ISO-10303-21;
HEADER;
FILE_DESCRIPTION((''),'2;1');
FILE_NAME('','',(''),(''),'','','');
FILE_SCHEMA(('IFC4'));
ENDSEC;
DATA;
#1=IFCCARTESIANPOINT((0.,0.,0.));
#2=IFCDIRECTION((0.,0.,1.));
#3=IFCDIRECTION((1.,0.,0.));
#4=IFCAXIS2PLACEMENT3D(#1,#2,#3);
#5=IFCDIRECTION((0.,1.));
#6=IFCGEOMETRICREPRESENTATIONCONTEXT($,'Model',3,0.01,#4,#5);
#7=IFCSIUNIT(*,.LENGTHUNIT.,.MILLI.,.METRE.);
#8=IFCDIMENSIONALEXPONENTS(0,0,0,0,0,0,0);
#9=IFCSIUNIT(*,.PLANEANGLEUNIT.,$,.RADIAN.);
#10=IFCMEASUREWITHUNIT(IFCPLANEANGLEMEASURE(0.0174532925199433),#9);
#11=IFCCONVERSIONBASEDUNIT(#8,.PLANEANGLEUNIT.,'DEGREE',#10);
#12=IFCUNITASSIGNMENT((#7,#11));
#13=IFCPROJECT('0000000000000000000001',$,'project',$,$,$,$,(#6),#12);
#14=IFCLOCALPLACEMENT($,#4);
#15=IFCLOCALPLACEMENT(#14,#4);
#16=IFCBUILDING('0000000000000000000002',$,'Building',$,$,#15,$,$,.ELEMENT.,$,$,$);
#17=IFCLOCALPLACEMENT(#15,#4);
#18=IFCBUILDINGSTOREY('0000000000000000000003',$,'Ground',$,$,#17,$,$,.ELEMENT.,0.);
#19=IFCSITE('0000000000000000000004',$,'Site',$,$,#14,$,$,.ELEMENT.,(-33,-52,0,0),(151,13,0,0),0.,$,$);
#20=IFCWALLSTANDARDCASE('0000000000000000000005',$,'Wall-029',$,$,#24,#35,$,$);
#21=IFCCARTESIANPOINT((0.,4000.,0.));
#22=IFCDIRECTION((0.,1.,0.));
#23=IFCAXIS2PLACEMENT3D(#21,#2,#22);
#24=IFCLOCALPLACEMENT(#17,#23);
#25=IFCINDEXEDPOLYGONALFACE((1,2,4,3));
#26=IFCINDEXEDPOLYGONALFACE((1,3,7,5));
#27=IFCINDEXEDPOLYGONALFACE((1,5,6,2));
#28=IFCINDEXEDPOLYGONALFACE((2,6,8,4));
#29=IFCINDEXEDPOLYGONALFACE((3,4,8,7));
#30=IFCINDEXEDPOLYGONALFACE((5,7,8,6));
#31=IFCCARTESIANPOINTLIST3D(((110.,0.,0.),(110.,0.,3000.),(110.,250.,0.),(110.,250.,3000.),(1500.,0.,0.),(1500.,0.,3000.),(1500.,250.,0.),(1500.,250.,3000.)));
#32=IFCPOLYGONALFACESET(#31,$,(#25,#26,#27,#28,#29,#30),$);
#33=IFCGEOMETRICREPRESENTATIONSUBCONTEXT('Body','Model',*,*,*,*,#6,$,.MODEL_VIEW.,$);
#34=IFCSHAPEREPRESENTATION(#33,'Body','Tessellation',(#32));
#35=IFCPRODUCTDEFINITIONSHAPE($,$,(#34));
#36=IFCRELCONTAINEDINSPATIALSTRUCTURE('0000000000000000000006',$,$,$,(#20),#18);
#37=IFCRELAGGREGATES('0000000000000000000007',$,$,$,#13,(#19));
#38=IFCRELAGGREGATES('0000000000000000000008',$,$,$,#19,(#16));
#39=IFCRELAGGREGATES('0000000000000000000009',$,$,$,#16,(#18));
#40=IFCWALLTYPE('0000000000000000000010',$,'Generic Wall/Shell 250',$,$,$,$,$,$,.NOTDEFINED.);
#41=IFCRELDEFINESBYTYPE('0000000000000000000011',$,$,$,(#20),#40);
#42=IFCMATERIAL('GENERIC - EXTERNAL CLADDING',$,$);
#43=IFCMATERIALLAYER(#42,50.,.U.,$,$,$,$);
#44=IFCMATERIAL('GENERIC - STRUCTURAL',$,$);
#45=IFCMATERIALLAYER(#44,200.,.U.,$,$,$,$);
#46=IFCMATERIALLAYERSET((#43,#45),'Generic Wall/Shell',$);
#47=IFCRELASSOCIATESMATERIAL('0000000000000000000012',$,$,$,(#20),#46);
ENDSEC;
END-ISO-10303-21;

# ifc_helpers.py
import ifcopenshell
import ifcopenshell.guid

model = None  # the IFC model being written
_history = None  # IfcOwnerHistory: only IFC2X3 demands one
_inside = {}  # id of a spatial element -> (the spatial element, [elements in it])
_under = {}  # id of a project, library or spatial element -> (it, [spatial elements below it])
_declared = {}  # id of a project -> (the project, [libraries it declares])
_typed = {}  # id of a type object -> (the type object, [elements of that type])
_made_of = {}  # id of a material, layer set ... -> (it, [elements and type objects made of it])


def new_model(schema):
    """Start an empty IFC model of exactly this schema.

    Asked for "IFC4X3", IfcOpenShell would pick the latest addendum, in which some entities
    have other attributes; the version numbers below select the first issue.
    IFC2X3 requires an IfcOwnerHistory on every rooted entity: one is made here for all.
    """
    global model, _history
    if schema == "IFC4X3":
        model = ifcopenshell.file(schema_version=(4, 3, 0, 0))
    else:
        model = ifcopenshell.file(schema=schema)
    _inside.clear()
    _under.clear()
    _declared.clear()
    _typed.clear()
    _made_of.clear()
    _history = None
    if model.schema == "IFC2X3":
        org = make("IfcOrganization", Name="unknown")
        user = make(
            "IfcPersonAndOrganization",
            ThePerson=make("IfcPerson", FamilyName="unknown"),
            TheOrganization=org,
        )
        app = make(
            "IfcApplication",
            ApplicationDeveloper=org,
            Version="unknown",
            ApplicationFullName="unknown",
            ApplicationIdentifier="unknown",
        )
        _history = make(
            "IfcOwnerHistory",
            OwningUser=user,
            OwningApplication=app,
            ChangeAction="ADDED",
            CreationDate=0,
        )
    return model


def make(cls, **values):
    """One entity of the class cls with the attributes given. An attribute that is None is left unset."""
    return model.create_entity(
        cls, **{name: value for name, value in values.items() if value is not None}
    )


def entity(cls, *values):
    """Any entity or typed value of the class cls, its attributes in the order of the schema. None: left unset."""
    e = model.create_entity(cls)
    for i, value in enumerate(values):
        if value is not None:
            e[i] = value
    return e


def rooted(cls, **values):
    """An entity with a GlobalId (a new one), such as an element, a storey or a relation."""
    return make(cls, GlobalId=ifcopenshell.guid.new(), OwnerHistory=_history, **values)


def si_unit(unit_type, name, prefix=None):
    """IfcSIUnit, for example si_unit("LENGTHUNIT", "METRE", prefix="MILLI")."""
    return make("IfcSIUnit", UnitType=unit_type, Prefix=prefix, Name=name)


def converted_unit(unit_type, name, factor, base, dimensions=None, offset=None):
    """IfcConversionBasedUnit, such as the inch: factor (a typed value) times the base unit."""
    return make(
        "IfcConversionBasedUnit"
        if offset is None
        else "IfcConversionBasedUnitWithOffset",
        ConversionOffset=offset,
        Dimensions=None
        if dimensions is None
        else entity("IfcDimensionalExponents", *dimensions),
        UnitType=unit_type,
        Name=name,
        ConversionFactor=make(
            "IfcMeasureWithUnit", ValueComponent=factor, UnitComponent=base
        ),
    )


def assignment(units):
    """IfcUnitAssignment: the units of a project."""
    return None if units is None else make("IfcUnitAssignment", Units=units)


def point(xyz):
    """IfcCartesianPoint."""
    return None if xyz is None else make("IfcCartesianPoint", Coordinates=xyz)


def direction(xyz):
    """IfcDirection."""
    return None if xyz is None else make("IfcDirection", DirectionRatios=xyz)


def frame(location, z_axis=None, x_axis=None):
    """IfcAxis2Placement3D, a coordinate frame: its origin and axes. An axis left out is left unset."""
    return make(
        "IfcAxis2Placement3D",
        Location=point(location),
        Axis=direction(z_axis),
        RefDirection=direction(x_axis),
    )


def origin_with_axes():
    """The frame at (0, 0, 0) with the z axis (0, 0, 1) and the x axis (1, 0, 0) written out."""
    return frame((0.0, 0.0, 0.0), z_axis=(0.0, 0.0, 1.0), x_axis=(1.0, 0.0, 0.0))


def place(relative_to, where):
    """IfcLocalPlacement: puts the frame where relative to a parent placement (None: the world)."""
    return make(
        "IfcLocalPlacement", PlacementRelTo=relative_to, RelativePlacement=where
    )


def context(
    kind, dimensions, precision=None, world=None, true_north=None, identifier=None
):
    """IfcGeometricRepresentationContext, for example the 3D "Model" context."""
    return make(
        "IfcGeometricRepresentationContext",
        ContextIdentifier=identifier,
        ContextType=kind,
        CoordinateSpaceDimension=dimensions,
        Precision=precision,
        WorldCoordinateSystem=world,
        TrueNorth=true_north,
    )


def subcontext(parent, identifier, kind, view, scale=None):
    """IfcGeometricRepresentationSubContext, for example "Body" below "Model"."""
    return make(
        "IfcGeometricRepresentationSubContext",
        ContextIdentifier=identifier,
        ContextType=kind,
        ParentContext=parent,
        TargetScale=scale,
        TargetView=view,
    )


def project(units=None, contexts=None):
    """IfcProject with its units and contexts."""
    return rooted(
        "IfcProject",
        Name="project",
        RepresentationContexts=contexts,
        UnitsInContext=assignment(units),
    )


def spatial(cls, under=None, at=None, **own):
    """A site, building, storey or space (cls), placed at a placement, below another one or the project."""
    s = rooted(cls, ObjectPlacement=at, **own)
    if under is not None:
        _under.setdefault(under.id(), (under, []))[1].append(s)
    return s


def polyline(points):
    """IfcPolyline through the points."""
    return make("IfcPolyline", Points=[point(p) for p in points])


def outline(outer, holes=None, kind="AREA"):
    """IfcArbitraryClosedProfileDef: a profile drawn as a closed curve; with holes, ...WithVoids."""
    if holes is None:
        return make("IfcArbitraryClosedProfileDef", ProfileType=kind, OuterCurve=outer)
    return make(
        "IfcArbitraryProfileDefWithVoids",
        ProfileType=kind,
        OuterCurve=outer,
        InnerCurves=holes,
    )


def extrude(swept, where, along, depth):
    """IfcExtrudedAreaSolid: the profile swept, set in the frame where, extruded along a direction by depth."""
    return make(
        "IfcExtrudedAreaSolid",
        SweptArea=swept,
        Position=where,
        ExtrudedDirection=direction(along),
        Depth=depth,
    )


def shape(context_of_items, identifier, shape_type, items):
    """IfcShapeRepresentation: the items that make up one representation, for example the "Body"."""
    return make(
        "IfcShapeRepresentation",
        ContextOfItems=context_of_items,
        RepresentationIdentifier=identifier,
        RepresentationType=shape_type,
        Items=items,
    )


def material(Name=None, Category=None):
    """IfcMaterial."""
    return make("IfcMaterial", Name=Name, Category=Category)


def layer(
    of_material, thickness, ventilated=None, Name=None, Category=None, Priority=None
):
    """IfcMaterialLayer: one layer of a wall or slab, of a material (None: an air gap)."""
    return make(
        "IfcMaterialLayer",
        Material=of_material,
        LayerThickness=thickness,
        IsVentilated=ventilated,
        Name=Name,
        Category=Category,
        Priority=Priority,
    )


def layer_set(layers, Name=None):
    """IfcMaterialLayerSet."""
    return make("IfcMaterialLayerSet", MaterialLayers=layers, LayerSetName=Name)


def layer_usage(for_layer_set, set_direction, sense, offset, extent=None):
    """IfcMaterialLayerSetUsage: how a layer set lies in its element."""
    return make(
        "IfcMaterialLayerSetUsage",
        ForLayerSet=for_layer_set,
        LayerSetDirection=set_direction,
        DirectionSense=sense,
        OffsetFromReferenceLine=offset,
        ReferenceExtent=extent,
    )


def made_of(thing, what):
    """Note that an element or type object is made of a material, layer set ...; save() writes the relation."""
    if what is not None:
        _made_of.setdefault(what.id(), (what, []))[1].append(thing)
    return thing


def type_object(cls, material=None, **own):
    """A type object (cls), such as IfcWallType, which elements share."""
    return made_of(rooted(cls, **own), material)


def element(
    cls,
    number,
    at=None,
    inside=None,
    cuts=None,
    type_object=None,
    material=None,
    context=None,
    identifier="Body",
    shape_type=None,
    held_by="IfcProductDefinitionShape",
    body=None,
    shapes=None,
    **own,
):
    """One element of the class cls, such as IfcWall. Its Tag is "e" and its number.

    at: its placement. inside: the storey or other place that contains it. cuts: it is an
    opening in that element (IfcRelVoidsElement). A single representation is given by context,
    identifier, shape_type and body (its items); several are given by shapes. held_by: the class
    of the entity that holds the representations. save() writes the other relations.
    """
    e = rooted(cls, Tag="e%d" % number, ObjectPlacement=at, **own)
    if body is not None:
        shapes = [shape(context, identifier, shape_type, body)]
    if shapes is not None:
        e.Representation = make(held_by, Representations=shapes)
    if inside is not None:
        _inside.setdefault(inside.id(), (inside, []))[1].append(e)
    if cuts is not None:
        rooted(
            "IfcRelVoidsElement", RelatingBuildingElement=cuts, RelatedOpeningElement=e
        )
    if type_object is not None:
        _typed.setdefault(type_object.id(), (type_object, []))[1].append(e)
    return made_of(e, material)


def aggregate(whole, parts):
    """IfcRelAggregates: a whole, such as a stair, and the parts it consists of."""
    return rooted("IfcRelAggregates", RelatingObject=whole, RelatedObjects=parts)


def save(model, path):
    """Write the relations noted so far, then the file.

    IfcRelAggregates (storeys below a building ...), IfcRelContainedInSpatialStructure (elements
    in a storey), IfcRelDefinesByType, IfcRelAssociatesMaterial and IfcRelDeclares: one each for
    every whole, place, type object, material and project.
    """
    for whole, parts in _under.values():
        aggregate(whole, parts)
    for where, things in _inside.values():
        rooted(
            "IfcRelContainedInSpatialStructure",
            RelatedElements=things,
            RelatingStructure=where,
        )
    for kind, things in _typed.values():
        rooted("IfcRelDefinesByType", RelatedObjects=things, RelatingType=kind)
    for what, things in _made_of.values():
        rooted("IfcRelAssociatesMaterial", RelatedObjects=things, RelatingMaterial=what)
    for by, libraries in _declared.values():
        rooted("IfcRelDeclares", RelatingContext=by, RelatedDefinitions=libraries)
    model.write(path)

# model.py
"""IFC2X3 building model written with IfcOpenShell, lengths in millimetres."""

from ifc_helpers import new_model, entity, si_unit, converted_unit, direction, frame, origin_with_axes, place, context, subcontext, project, spatial, polyline, outline, extrude, material, layer, layer_set, layer_usage, type_object, element, save


model = new_model("IFC2X3")

# Units and contexts
model_context = context("Model", 3, precision=0.01, world=origin_with_axes(), true_north=direction((0.0, 1.0)))
body_context = subcontext(model_context, "Body", "Model", "MODEL_VIEW")
ifc_project = project(units=[si_unit("LENGTHUNIT", "METRE", prefix="MILLI"), converted_unit("PLANEANGLEUNIT", "DEGREE", entity("IfcPlaneAngleMeasure", 0.0174532925199433), si_unit("PLANEANGLEUNIT", "RADIAN"), dimensions=[0, 0, 0, 0, 0, 0, 0])], contexts=[model_context])

# Site, building, storey
site_placement = place(None, origin_with_axes())
site = spatial("IfcSite", under=ifc_project, at=site_placement, Name="Site", CompositionType="ELEMENT", RefLatitude=(-33, -52, 0, 0), RefLongitude=(151, 13, 0, 0), RefElevation=0.0)
building_placement = place(site_placement, origin_with_axes())
building = spatial("IfcBuilding", under=site, at=building_placement, Name="Building", CompositionType="ELEMENT")
storey_placement = place(building_placement, origin_with_axes())
storey = spatial("IfcBuildingStorey", under=building, at=storey_placement, Name="Ground", CompositionType="ELEMENT", Elevation=0.0)

# Shared definitions
ifc_material_1 = material(Name="GENERIC - STRUCTURAL")

# Wall
ifc_material_2 = material(Name="GENERIC - EXTERNAL CLADDING")
ifc_layer_1 = layer(ifc_material_2, 50.0, ventilated="UNKNOWN")
ifc_layer_2 = layer(ifc_material_1, 200.0, ventilated="UNKNOWN")
ifc_layer_set_1 = layer_set([ifc_layer_1, ifc_layer_2], Name="Generic Wall/Shell")
wall_type_1 = type_object("IfcWallType", Name="Generic Wall/Shell 250", PredefinedType="NOTDEFINED")
ifc_layer_usage_1 = layer_usage(ifc_layer_set_1, "AXIS2", "POSITIVE", 0.0)
wall_1_placement = place(storey_placement, frame((0.0, 4000.0, 0.0), z_axis=(0.0, 0.0, 1.0), x_axis=(0.0, 1.0, 0.0)))
element("IfcWallStandardCase", 1, at=wall_1_placement, inside=storey, type_object=wall_type_1, material=ifc_layer_usage_1, Name="Wall-029", context=body_context, shape_type="SweptSolid", body=[
    extrude(outline(polyline([(110.0, 0.0), (1500.0, 0.0), (1500.0, 250.0), (110.0, 250.0), (110.0, 0.0)])), origin_with_axes(), (0.0, 0.0, 1.0), 3000.0),
])

save(model, "model.ifc")
